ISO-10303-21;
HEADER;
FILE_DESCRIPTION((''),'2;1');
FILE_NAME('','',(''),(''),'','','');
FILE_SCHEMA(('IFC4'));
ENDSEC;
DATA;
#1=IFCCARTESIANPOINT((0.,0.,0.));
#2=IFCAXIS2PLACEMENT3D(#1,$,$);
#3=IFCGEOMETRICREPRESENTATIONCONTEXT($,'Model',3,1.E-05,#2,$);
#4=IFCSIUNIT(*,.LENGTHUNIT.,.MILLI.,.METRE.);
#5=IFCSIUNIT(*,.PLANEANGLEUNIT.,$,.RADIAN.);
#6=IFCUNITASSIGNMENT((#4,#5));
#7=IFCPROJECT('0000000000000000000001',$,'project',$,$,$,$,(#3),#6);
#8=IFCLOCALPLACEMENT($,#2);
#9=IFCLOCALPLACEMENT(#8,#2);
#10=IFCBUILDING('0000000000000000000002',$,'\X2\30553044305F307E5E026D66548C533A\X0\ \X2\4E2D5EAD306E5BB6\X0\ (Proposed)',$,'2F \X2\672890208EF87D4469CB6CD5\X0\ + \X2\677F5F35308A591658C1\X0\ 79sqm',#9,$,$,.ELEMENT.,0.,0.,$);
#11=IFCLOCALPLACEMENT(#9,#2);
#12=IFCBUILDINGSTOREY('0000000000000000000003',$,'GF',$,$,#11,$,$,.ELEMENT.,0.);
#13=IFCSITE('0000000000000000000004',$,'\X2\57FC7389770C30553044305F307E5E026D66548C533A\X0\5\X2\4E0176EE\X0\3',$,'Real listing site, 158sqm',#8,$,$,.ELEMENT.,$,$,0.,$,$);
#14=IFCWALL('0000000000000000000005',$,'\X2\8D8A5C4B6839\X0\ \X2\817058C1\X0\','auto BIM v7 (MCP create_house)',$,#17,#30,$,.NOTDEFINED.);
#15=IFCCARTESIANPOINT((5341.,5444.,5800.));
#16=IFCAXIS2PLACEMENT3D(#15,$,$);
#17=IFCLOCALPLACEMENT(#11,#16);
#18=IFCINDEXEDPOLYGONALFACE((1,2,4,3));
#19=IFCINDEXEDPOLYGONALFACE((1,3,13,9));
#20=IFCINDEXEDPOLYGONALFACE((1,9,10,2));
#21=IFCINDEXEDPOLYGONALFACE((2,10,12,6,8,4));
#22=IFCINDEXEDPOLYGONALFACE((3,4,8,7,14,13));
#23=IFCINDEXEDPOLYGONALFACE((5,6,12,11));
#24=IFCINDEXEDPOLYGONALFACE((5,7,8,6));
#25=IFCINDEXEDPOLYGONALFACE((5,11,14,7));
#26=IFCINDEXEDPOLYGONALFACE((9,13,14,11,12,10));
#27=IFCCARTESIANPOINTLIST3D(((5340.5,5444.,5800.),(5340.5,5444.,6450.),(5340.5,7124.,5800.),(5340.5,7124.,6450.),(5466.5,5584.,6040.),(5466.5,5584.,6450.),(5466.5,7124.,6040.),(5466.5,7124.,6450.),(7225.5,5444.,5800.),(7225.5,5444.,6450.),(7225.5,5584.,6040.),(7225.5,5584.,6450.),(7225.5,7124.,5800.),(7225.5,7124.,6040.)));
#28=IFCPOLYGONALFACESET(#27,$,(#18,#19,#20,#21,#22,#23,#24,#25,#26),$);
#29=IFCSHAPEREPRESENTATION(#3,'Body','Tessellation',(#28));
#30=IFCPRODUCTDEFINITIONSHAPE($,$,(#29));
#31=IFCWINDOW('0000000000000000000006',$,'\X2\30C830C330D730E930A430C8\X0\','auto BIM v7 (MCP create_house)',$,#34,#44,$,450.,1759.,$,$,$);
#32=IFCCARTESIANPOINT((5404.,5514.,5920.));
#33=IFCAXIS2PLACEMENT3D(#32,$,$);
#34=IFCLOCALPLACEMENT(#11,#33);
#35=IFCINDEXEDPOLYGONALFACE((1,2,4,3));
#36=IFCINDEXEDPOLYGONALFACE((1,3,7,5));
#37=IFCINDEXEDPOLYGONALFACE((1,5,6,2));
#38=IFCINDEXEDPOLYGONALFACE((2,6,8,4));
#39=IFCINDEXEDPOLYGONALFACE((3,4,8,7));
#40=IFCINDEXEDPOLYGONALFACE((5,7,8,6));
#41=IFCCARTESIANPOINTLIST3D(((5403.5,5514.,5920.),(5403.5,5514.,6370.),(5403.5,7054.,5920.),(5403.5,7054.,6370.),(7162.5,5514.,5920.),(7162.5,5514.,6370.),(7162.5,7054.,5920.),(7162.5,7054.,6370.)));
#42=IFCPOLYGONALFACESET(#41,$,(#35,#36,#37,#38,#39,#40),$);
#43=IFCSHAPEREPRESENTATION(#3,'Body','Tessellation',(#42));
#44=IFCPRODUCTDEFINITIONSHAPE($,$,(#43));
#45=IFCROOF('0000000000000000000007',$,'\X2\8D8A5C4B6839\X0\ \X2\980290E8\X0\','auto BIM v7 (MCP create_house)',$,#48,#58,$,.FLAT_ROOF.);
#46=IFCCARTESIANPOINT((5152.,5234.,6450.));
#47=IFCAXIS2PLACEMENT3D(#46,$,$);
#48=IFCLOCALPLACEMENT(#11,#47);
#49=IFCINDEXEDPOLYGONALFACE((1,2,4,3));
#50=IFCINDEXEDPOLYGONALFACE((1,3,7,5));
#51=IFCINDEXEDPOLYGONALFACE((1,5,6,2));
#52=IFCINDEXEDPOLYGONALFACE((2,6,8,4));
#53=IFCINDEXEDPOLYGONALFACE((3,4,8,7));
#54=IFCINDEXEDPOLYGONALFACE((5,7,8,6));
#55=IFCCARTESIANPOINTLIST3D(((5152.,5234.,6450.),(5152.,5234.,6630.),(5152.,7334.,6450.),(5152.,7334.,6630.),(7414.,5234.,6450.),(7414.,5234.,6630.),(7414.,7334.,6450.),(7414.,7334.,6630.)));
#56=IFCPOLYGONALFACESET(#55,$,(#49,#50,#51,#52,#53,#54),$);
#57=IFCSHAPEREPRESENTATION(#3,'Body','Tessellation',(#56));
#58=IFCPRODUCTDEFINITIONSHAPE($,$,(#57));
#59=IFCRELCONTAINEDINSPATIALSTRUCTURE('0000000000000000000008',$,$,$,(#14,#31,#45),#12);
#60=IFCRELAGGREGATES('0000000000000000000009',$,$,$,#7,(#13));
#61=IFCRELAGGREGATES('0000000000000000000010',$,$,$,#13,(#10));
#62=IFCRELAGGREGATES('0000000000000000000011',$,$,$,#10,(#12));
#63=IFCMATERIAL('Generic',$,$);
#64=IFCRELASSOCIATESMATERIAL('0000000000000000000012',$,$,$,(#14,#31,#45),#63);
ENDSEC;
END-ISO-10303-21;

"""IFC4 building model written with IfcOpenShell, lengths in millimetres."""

from ifc_helpers import new_model, si_unit, frame, frame_2d, origin, place, context, project, spatial, rectangle, extrude, material, element, fill, save


model = new_model("IFC4")

# Units and contexts
model_context = context("Model", 3, precision=1e-05, world=origin())
ifc_project = project(units=[si_unit("LENGTHUNIT", "METRE", prefix="MILLI"), si_unit("PLANEANGLEUNIT", "RADIAN")], contexts=[model_context])

# Site, building, storey
site_placement = place(None, origin())
site = spatial("IfcSite", under=ifc_project, at=site_placement, Name="埼玉県さいたま市浦和区5丁目3", ObjectType="Real listing site, 158sqm", CompositionType="ELEMENT", RefElevation=0.0)
building_placement = place(site_placement, origin())
building = spatial("IfcBuilding", under=site, at=building_placement, Name="さいたま市浦和区 中庭の家 (Proposed)", ObjectType="2F 木造軸組構法 + 板張り外壁 79sqm", CompositionType="ELEMENT", ElevationOfRefHeight=0.0, ElevationOfTerrain=0.0)
storey_placement = place(building_placement, origin())
storey = spatial("IfcBuildingStorey", under=building, at=storey_placement, Name="GF", CompositionType="ELEMENT", Elevation=0.0)

# Shared definitions
ifc_material = material(Name="Generic")

# Wall, opening, window
wall_1_placement = place(storey_placement, frame((5341.0, 5444.0, 5800.0)))
wall_1 = element("IfcWall", 1, at=wall_1_placement, inside=storey, material=ifc_material, Name="越屋根 腰壁", Description="auto BIM v7 (MCP create_house)", PredefinedType="NOTDEFINED", context=model_context, shape_type="SweptSolid", body=[
    extrude(rectangle(XDim=1885.0, YDim=1680.0, at=frame_2d((942.0, 840.0))), frame((5341.0, 5444.0, 5800.0)), (0.0, 0.0, 1.0), 650.0),
])
opening_1_placement = place(storey_placement, frame((5404.0, 5514.0, 5920.0)))
opening_1 = element("IfcOpeningElement", 2, at=opening_1_placement, cuts=wall_1, PredefinedType="NOTDEFINED", context=model_context, shape_type="SweptSolid", body=[
    extrude(rectangle(XDim=1759.0, YDim=1540.0, at=frame_2d((879.0, 770.0))), frame((5404.0, 5514.0, 5920.0)), (0.0, 0.0, 1.0), 450.0),
])
window_1_placement = place(storey_placement, frame((5404.0, 5514.0, 5920.0)))
window_1 = element("IfcWindow", 3, at=window_1_placement, inside=storey, material=ifc_material, Name="トップライト", Description="auto BIM v7 (MCP create_house)", OverallHeight=450.0, OverallWidth=1759.0, context=model_context, shape_type="SweptSolid", body=[
    extrude(rectangle(XDim=1759.0, YDim=1540.0, at=frame_2d((879.0, 770.0))), frame((5404.0, 5514.0, 5920.0)), (0.0, 0.0, 1.0), 450.0),
])
fill(opening_1, window_1)

# Roof
roof_placement = place(storey_placement, frame((5152.0, 5234.0, 6450.0)))
element("IfcRoof", 4, at=roof_placement, inside=storey, material=ifc_material, Name="越屋根 頂部", Description="auto BIM v7 (MCP create_house)", PredefinedType="FLAT_ROOF", context=model_context, shape_type="SweptSolid", body=[
    extrude(rectangle(XDim=2262.0, YDim=2100.0, at=frame_2d((1131.0, 1050.0))), frame((5152.0, 5234.0, 6450.0)), (0.0, 0.0, 1.0), 180.0),
])

save(model, "model.ifc")
